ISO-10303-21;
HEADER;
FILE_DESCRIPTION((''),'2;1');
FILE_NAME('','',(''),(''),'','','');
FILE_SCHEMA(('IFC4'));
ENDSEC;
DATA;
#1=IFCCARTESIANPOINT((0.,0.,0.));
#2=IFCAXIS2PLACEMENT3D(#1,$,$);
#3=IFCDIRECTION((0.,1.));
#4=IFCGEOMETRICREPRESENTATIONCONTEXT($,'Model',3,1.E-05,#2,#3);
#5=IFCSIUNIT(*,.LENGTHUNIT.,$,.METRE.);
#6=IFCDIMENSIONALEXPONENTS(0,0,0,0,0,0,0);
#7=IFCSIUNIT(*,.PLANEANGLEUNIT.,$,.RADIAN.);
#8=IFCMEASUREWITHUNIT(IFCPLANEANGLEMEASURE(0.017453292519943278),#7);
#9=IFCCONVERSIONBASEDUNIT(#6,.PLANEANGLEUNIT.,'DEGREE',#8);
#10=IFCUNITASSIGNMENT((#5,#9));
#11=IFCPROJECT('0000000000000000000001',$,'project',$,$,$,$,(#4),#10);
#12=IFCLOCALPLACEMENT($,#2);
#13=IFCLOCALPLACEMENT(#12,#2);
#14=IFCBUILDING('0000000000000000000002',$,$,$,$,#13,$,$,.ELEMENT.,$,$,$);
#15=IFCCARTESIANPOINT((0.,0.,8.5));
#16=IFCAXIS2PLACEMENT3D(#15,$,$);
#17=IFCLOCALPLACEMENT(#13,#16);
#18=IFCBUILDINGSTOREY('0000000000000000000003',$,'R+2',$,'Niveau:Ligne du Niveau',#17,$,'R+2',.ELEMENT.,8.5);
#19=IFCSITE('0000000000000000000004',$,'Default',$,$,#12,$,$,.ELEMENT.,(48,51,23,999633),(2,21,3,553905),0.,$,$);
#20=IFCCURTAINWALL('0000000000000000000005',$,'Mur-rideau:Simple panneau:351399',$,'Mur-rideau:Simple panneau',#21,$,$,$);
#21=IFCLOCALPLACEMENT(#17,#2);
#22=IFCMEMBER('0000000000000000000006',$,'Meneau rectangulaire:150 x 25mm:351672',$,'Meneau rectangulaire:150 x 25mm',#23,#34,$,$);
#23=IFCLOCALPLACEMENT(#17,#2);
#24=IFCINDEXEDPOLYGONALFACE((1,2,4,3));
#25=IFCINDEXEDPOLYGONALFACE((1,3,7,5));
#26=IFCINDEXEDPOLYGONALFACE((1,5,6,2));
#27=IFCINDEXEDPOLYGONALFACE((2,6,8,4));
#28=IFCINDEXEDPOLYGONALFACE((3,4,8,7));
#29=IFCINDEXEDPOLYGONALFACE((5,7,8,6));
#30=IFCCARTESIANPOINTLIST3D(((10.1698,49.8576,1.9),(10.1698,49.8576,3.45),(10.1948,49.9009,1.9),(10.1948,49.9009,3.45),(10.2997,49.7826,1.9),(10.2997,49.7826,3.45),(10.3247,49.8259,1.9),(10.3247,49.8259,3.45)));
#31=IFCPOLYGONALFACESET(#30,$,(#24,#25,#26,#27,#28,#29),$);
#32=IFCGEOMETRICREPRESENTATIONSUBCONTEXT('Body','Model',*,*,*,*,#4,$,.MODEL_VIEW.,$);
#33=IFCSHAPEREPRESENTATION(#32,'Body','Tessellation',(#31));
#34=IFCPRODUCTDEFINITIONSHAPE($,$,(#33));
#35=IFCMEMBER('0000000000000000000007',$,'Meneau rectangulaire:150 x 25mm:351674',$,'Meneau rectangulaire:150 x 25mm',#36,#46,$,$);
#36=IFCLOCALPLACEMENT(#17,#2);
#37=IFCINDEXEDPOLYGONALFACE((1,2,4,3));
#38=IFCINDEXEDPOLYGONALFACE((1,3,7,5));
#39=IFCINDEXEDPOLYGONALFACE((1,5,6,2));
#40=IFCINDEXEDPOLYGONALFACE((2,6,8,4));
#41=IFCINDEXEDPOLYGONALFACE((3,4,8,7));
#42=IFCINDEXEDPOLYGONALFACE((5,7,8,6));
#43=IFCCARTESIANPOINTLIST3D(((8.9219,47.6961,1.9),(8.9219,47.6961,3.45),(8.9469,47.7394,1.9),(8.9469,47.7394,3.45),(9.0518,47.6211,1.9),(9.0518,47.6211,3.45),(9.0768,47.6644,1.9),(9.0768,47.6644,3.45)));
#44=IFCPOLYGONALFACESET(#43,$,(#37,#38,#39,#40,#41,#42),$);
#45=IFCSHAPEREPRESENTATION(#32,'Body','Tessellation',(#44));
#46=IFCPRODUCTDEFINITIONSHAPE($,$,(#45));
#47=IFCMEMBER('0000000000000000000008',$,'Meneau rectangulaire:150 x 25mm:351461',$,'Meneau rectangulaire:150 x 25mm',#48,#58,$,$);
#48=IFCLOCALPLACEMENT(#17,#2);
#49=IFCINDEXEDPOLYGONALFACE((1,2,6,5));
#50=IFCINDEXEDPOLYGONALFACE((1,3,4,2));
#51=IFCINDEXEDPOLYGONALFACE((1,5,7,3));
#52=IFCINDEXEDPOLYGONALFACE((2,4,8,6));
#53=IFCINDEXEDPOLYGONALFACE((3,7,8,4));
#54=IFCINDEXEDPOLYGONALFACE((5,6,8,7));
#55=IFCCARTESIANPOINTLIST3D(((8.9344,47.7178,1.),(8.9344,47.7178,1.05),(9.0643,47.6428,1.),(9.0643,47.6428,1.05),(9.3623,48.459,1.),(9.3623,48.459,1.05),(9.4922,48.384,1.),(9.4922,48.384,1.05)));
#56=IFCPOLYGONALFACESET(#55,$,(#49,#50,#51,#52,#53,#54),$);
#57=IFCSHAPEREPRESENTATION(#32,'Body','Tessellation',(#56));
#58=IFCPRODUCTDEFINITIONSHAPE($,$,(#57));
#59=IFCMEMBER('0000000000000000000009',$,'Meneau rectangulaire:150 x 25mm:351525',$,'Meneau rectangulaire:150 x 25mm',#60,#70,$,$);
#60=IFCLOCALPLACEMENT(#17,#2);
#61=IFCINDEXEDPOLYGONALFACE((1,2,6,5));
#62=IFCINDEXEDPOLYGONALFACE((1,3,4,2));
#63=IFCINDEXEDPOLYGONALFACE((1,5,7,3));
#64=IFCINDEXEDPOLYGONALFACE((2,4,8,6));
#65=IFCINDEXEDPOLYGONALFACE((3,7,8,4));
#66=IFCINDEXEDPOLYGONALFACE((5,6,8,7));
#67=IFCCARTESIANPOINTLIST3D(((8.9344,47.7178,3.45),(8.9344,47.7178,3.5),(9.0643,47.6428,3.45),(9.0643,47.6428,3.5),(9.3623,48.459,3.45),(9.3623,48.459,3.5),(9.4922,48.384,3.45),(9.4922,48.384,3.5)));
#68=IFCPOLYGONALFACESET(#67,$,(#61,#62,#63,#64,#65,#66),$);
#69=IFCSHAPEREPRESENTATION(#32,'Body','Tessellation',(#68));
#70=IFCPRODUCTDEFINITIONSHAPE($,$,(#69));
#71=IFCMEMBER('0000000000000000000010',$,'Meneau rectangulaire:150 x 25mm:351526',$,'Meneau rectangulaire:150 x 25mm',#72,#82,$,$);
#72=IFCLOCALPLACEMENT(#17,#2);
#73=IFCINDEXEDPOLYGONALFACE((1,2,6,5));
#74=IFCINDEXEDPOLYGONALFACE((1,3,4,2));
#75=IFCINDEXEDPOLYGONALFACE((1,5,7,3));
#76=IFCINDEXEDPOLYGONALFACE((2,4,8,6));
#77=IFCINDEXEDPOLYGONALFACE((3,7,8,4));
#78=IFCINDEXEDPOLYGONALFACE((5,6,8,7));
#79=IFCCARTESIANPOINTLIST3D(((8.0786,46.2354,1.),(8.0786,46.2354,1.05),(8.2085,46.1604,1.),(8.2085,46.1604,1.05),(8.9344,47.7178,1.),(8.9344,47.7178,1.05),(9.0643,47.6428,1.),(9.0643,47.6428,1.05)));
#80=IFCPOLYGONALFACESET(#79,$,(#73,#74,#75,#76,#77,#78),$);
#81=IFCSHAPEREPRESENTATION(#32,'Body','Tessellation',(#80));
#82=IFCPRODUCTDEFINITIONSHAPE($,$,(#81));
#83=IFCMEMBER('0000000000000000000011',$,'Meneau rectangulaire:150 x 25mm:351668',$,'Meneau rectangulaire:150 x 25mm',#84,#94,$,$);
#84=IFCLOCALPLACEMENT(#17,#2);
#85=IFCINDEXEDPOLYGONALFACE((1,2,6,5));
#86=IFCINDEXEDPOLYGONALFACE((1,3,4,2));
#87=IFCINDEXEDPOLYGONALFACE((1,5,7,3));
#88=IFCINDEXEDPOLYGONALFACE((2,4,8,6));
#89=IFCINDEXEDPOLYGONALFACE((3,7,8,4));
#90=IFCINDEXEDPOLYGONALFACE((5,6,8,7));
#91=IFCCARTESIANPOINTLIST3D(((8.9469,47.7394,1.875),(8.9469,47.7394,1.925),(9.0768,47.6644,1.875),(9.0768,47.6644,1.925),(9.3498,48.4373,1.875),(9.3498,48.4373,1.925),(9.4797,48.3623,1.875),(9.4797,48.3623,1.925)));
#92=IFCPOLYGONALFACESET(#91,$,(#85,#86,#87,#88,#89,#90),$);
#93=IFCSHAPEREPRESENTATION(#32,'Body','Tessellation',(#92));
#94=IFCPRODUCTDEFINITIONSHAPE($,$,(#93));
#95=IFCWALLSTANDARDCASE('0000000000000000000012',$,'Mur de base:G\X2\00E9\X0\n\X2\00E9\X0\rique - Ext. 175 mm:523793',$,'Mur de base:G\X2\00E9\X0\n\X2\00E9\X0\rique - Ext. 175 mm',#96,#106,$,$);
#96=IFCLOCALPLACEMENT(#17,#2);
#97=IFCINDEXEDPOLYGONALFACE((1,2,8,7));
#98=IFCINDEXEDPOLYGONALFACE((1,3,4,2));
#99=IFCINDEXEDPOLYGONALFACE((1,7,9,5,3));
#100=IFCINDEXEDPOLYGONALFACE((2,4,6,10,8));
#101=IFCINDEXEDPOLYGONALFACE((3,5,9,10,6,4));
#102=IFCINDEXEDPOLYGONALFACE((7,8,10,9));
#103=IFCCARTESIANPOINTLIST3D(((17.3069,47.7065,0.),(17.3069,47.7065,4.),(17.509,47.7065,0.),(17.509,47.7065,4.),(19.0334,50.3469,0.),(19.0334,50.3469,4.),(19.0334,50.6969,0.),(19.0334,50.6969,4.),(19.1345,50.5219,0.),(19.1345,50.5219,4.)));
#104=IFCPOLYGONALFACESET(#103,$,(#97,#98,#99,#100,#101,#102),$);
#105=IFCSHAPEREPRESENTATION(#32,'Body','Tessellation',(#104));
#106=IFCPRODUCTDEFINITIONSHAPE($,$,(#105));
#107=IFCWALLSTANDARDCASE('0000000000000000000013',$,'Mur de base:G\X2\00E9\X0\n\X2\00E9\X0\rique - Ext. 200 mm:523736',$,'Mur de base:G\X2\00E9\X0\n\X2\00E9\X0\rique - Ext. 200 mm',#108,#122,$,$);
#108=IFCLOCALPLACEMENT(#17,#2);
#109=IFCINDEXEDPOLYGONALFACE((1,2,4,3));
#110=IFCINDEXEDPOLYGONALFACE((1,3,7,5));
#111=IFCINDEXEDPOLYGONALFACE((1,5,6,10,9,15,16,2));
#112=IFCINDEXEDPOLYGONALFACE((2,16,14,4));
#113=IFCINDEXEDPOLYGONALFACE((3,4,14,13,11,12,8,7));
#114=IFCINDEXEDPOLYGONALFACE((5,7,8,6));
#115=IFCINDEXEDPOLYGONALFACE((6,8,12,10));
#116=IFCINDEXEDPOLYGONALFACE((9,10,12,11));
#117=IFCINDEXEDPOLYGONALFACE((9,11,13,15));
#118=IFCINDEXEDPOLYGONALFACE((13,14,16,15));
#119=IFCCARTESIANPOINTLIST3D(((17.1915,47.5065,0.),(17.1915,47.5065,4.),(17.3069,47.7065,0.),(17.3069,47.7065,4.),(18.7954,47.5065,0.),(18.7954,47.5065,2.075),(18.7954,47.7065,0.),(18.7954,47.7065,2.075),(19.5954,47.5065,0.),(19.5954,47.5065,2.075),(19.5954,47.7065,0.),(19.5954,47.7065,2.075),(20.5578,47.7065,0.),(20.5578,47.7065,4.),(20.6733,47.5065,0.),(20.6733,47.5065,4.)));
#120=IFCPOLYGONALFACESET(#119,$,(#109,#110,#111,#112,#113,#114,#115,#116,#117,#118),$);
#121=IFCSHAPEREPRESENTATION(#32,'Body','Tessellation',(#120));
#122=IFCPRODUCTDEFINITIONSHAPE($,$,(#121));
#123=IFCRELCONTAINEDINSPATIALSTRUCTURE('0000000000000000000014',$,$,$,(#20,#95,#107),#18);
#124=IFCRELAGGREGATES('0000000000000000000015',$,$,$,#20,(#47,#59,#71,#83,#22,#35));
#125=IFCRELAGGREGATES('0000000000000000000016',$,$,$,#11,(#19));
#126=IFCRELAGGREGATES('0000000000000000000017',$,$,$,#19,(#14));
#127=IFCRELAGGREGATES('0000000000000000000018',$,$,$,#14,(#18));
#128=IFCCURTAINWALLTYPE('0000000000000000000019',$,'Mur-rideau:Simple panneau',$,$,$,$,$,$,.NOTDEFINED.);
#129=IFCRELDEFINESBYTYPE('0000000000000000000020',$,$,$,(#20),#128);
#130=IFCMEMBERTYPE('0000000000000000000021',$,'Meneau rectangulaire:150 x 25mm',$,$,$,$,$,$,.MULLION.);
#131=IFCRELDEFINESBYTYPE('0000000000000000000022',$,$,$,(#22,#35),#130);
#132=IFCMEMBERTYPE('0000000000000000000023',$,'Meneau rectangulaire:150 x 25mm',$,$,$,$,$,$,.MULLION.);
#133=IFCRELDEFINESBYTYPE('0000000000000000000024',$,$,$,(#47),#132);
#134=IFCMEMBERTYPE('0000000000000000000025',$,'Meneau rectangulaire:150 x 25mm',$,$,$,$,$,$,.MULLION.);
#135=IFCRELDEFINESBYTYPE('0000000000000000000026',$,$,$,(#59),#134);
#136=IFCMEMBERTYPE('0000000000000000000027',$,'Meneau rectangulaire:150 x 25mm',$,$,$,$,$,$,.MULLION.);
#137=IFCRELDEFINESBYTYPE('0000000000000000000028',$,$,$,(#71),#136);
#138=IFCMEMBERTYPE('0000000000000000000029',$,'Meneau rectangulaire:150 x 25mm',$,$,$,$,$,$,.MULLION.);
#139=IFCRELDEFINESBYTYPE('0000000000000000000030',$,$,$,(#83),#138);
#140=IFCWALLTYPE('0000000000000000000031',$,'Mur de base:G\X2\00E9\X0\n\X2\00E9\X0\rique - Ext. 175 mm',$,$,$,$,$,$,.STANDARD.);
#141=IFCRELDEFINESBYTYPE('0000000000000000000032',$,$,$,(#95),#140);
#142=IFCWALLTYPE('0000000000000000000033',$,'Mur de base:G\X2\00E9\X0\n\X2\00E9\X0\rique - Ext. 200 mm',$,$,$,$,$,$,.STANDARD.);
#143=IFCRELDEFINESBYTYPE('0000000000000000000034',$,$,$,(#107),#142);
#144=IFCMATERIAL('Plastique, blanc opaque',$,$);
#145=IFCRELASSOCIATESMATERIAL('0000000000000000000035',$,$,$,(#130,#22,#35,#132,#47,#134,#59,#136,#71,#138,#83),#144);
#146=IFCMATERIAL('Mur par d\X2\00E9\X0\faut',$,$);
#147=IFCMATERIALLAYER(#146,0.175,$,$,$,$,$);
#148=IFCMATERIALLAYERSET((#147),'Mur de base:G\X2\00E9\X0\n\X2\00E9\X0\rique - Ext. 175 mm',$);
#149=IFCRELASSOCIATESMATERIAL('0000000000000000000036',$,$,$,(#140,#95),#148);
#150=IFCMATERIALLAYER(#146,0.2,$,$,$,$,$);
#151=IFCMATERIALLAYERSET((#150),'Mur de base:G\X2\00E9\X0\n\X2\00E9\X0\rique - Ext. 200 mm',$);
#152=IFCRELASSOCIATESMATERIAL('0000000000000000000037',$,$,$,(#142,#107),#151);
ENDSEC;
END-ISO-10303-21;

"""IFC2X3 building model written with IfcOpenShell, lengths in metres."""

from ifc_helpers import new_model, entity, si_unit, converted_unit, direction, frame, frame_2d, origin, origin_2d_with_axis, place, context, subcontext, project, spatial, polyline, rectangle, outline, extrude, source, transform, mapped, material, layer, layer_set, layer_usage, type_object, type_shapes, element, aggregate, save


model = new_model("IFC2X3")

# Units and contexts
model_context = context("Model", 3, precision=1e-05, world=origin(), true_north=direction((0.0, 1.0)))
body_context = subcontext(model_context, "Body", "Model", "MODEL_VIEW")
ifc_project = project(units=[si_unit("LENGTHUNIT", "METRE"), converted_unit("PLANEANGLEUNIT", "DEGREE", entity("IfcPlaneAngleMeasure", 0.017453292519943278), si_unit("PLANEANGLEUNIT", "RADIAN"), dimensions=[0, 0, 0, 0, 0, 0, 0])], contexts=[model_context])

# Site, building, storey
site_placement = place(None, origin())
site = spatial("IfcSite", under=ifc_project, at=site_placement, Name="Default", CompositionType="ELEMENT", RefLatitude=(48, 51, 23, 999633), RefLongitude=(2, 21, 3, 553905), RefElevation=0.0)
building_placement = place(site_placement, origin())
building = spatial("IfcBuilding", under=site, at=building_placement, CompositionType="ELEMENT")
storey_placement = place(building_placement, frame((0.0, 0.0, 8.5)))
storey = spatial("IfcBuildingStorey", under=building, at=storey_placement, Name="R+2", ObjectType="Niveau:Ligne du Niveau", LongName="R+2", CompositionType="ELEMENT", Elevation=8.5)

# Curtain wall, members
curtain_wall_type = type_object("IfcCurtainWallType", Name="Mur-rideau:Simple panneau", PredefinedType="NOTDEFINED")
curtain_wall_placement = place(storey_placement, frame((0.0, 0.0, -8.5)))
curtain_wall = element("IfcCurtainWall", 1, at=curtain_wall_placement, inside=storey, type_object=curtain_wall_type, Name="Mur-rideau:Simple panneau:351399", ObjectType="Mur-rideau:Simple panneau")
ifc_material_1 = material(Name="Plastique, blanc opaque")
member_type_1 = type_object("IfcMemberType", Name="Meneau rectangulaire:150 x 25mm", PredefinedType="MULLION", material=ifc_material_1)
shared_shape_1 = source(origin(), body_context, "Body", "SweptSolid", [
    extrude(rectangle(XDim=0.05, YDim=0.15, at=origin_2d_with_axis()), frame((0.0, 0.0, -1.55), z_axis=(0.0, 0.0, 1.0), x_axis=(-1.0, 0.0, 0.0)), (0.0, 0.0, 1.0), 1.55),
])
type_shapes(member_type_1, [shared_shape_1])
member_1_placement = place(curtain_wall_placement, frame((10.2473, 49.8417, 10.4), z_axis=(0.0, 0.0, -1.0), x_axis=(-0.5, -0.866025, 0.0)))
member_1 = element("IfcMember", 2, at=member_1_placement, type_object=member_type_1, material=ifc_material_1, Name="Meneau rectangulaire:150 x 25mm:351672", ObjectType="Meneau rectangulaire:150 x 25mm", context=body_context, shape_type="MappedRepresentation", body=[
    mapped(shared_shape_1, transform((0.0, 0.0, 0.0), scale=1.0)),
])
member_2_placement = place(curtain_wall_placement, frame((8.9994, 47.6803, 10.4), z_axis=(0.0, 0.0, -1.0), x_axis=(-0.5, -0.866025, 0.0)))
member_2 = element("IfcMember", 3, at=member_2_placement, type_object=member_type_1, material=ifc_material_1, Name="Meneau rectangulaire:150 x 25mm:351674", ObjectType="Meneau rectangulaire:150 x 25mm", context=body_context, shape_type="MappedRepresentation", body=[
    mapped(shared_shape_1, transform((0.0, 0.0, 0.0), scale=1.0)),
])
member_type_2 = type_object("IfcMemberType", Name="Meneau rectangulaire:150 x 25mm", PredefinedType="MULLION", material=ifc_material_1)
shared_shape_2 = source(origin(), body_context, "Body", "SweptSolid", [
    extrude(rectangle(XDim=0.05, YDim=0.15, at=origin_2d_with_axis()), frame((-0.025, 0.0, -0.8558), z_axis=(0.0, 0.0, 1.0), x_axis=(-1.0, 0.0, 0.0)), (0.0, 0.0, 1.0), 0.8558),
])
type_shapes(member_type_2, [shared_shape_2])
member_3_placement = place(curtain_wall_placement, frame((9.4273, 48.4215, 9.5), z_axis=(0.5, 0.866025, 0.0), x_axis=(0.0, 0.0, -1.0)))
member_3 = element("IfcMember", 4, at=member_3_placement, type_object=member_type_2, material=ifc_material_1, Name="Meneau rectangulaire:150 x 25mm:351461", ObjectType="Meneau rectangulaire:150 x 25mm", context=body_context, shape_type="MappedRepresentation", body=[
    mapped(shared_shape_2, transform((0.0, 0.0, 0.0), scale=1.0)),
])
member_type_3 = type_object("IfcMemberType", Name="Meneau rectangulaire:150 x 25mm", PredefinedType="MULLION", material=ifc_material_1)
shared_shape_3 = source(origin(), body_context, "Body", "SweptSolid", [
    extrude(rectangle(XDim=0.05, YDim=0.15, at=origin_2d_with_axis()), frame((-0.025, 0.0, -0.8558), z_axis=(0.0, 0.0, 1.0), x_axis=(-1.0, 0.0, 0.0)), (0.0, 0.0, 1.0), 0.8558),
])
type_shapes(member_type_3, [shared_shape_3])
member_4_placement = place(curtain_wall_placement, frame((8.9994, 47.6803, 12.0), z_axis=(-0.5, -0.866025, 0.0), x_axis=(0.0, 0.0, 1.0)))
member_4 = element("IfcMember", 5, at=member_4_placement, type_object=member_type_3, material=ifc_material_1, Name="Meneau rectangulaire:150 x 25mm:351525", ObjectType="Meneau rectangulaire:150 x 25mm", context=body_context, shape_type="MappedRepresentation", body=[
    mapped(shared_shape_3, transform((0.0, 0.0, 0.0), scale=1.0)),
])
member_type_4 = type_object("IfcMemberType", Name="Meneau rectangulaire:150 x 25mm", PredefinedType="MULLION", material=ifc_material_1)
shared_shape_4 = source(origin(), body_context, "Body", "SweptSolid", [
    extrude(rectangle(XDim=0.05, YDim=0.15, at=origin_2d_with_axis()), frame((-0.025, 0.0, -1.7117), z_axis=(0.0, 0.0, 1.0), x_axis=(-1.0, 0.0, 0.0)), (0.0, 0.0, 1.0), 1.7117),
])
type_shapes(member_type_4, [shared_shape_4])
member_5_placement = place(curtain_wall_placement, frame((8.9994, 47.6803, 9.5), z_axis=(0.5, 0.866025, 0.0), x_axis=(0.0, 0.0, -1.0)))
member_5 = element("IfcMember", 6, at=member_5_placement, type_object=member_type_4, material=ifc_material_1, Name="Meneau rectangulaire:150 x 25mm:351526", ObjectType="Meneau rectangulaire:150 x 25mm", context=body_context, shape_type="MappedRepresentation", body=[
    mapped(shared_shape_4, transform((0.0, 0.0, 0.0), scale=1.0)),
])
member_type_5 = type_object("IfcMemberType", Name="Meneau rectangulaire:150 x 25mm", PredefinedType="MULLION", material=ifc_material_1)
shared_shape_5 = source(origin(), body_context, "Body", "SweptSolid", [
    extrude(rectangle(XDim=0.05, YDim=0.15, at=origin_2d_with_axis()), frame((0.0, 0.0, -0.8058), z_axis=(0.0, 0.0, 1.0), x_axis=(-1.0, 0.0, 0.0)), (0.0, 0.0, 1.0), 0.8058),
])
type_shapes(member_type_5, [shared_shape_5])
member_6_placement = place(curtain_wall_placement, frame((9.0119, 47.7019, 10.4), z_axis=(-0.5, -0.866025, 0.0), x_axis=(0.0, 0.0, 1.0)))
member_6 = element("IfcMember", 7, at=member_6_placement, type_object=member_type_5, material=ifc_material_1, Name="Meneau rectangulaire:150 x 25mm:351668", ObjectType="Meneau rectangulaire:150 x 25mm", context=body_context, shape_type="MappedRepresentation", body=[
    mapped(shared_shape_5, transform((0.0, 0.0, 0.0), scale=1.0)),
])
aggregate(curtain_wall, [member_3, member_4, member_5, member_6, member_1, member_2])

# Wall
ifc_material_2 = material(Name="Mur par défaut")
ifc_layer_1 = layer(ifc_material_2, 0.175)
ifc_layer_set_1 = layer_set([ifc_layer_1], Name="Mur de base:Générique - Ext. 175 mm")
ifc_layer_usage_1 = layer_usage(ifc_layer_set_1, "AXIS2", "NEGATIVE", 0.0875)
wall_type_1 = type_object("IfcWallType", Name="Mur de base:Générique - Ext. 175 mm", PredefinedType="STANDARD", material=ifc_layer_set_1)
wall_1_placement = place(storey_placement, frame((17.3827, 47.6628, 0.0), z_axis=(0.0, 0.0, 1.0), x_axis=(0.5, 0.866025, 0.0)))
element("IfcWallStandardCase", 8, at=wall_1_placement, inside=storey, type_object=wall_type_1, material=ifc_layer_usage_1, Name="Mur de base:Générique - Ext. 175 mm:523793", ObjectType="Mur de base:Générique - Ext. 175 mm", context=body_context, shape_type="SweptSolid", body=[
    extrude(outline(polyline([(3.3519, -0.0875), (3.4529, 0.0875), (0.0, 0.0875), (0.101, -0.0875), (3.1498, -0.0875), (3.3519, -0.0875)])), origin(), (0.0, 0.0, 1.0), 4.0),
])

# Wall, opening
ifc_layer_2 = layer(ifc_material_2, 0.2)
ifc_layer_set_2 = layer_set([ifc_layer_2], Name="Mur de base:Générique - Ext. 200 mm")
ifc_layer_usage_2 = layer_usage(ifc_layer_set_2, "AXIS2", "NEGATIVE", 0.1)
wall_type_2 = type_object("IfcWallType", Name="Mur de base:Générique - Ext. 200 mm", PredefinedType="STANDARD", material=ifc_layer_set_2)
wall_2_placement = place(storey_placement, frame((17.1915, 47.6065, 0.0)))
wall_2 = element("IfcWallStandardCase", 9, at=wall_2_placement, inside=storey, type_object=wall_type_2, material=ifc_layer_usage_2, Name="Mur de base:Générique - Ext. 200 mm:523736", ObjectType="Mur de base:Générique - Ext. 200 mm", context=body_context, shape_type="SweptSolid", body=[
    extrude(outline(polyline([(0.0, -0.1), (3.4818, -0.1), (3.3663, 0.1), (0.3175, 0.1), (0.1155, 0.1), (0.0, -0.1)])), origin(), (0.0, 0.0, 1.0), 4.0),
])
opening_placement = place(wall_2_placement, frame((2.4039, 0.1, 0.0)))
element("IfcOpeningElement", 10, at=opening_placement, cuts=wall_2, ObjectType="Opening", context=body_context, shape_type="SweptSolid", body=[
    extrude(rectangle(XDim=2.075, YDim=0.8, at=frame_2d((1.0375, 0.4), x_axis=(1.0, 0.0))), frame((0.0, 0.0, 0.0), z_axis=(0.0, -1.0, 0.0), x_axis=(0.0, 0.0, 1.0)), (0.0, 0.0, 1.0), 0.2),
])

save(model, "model.ifc")
